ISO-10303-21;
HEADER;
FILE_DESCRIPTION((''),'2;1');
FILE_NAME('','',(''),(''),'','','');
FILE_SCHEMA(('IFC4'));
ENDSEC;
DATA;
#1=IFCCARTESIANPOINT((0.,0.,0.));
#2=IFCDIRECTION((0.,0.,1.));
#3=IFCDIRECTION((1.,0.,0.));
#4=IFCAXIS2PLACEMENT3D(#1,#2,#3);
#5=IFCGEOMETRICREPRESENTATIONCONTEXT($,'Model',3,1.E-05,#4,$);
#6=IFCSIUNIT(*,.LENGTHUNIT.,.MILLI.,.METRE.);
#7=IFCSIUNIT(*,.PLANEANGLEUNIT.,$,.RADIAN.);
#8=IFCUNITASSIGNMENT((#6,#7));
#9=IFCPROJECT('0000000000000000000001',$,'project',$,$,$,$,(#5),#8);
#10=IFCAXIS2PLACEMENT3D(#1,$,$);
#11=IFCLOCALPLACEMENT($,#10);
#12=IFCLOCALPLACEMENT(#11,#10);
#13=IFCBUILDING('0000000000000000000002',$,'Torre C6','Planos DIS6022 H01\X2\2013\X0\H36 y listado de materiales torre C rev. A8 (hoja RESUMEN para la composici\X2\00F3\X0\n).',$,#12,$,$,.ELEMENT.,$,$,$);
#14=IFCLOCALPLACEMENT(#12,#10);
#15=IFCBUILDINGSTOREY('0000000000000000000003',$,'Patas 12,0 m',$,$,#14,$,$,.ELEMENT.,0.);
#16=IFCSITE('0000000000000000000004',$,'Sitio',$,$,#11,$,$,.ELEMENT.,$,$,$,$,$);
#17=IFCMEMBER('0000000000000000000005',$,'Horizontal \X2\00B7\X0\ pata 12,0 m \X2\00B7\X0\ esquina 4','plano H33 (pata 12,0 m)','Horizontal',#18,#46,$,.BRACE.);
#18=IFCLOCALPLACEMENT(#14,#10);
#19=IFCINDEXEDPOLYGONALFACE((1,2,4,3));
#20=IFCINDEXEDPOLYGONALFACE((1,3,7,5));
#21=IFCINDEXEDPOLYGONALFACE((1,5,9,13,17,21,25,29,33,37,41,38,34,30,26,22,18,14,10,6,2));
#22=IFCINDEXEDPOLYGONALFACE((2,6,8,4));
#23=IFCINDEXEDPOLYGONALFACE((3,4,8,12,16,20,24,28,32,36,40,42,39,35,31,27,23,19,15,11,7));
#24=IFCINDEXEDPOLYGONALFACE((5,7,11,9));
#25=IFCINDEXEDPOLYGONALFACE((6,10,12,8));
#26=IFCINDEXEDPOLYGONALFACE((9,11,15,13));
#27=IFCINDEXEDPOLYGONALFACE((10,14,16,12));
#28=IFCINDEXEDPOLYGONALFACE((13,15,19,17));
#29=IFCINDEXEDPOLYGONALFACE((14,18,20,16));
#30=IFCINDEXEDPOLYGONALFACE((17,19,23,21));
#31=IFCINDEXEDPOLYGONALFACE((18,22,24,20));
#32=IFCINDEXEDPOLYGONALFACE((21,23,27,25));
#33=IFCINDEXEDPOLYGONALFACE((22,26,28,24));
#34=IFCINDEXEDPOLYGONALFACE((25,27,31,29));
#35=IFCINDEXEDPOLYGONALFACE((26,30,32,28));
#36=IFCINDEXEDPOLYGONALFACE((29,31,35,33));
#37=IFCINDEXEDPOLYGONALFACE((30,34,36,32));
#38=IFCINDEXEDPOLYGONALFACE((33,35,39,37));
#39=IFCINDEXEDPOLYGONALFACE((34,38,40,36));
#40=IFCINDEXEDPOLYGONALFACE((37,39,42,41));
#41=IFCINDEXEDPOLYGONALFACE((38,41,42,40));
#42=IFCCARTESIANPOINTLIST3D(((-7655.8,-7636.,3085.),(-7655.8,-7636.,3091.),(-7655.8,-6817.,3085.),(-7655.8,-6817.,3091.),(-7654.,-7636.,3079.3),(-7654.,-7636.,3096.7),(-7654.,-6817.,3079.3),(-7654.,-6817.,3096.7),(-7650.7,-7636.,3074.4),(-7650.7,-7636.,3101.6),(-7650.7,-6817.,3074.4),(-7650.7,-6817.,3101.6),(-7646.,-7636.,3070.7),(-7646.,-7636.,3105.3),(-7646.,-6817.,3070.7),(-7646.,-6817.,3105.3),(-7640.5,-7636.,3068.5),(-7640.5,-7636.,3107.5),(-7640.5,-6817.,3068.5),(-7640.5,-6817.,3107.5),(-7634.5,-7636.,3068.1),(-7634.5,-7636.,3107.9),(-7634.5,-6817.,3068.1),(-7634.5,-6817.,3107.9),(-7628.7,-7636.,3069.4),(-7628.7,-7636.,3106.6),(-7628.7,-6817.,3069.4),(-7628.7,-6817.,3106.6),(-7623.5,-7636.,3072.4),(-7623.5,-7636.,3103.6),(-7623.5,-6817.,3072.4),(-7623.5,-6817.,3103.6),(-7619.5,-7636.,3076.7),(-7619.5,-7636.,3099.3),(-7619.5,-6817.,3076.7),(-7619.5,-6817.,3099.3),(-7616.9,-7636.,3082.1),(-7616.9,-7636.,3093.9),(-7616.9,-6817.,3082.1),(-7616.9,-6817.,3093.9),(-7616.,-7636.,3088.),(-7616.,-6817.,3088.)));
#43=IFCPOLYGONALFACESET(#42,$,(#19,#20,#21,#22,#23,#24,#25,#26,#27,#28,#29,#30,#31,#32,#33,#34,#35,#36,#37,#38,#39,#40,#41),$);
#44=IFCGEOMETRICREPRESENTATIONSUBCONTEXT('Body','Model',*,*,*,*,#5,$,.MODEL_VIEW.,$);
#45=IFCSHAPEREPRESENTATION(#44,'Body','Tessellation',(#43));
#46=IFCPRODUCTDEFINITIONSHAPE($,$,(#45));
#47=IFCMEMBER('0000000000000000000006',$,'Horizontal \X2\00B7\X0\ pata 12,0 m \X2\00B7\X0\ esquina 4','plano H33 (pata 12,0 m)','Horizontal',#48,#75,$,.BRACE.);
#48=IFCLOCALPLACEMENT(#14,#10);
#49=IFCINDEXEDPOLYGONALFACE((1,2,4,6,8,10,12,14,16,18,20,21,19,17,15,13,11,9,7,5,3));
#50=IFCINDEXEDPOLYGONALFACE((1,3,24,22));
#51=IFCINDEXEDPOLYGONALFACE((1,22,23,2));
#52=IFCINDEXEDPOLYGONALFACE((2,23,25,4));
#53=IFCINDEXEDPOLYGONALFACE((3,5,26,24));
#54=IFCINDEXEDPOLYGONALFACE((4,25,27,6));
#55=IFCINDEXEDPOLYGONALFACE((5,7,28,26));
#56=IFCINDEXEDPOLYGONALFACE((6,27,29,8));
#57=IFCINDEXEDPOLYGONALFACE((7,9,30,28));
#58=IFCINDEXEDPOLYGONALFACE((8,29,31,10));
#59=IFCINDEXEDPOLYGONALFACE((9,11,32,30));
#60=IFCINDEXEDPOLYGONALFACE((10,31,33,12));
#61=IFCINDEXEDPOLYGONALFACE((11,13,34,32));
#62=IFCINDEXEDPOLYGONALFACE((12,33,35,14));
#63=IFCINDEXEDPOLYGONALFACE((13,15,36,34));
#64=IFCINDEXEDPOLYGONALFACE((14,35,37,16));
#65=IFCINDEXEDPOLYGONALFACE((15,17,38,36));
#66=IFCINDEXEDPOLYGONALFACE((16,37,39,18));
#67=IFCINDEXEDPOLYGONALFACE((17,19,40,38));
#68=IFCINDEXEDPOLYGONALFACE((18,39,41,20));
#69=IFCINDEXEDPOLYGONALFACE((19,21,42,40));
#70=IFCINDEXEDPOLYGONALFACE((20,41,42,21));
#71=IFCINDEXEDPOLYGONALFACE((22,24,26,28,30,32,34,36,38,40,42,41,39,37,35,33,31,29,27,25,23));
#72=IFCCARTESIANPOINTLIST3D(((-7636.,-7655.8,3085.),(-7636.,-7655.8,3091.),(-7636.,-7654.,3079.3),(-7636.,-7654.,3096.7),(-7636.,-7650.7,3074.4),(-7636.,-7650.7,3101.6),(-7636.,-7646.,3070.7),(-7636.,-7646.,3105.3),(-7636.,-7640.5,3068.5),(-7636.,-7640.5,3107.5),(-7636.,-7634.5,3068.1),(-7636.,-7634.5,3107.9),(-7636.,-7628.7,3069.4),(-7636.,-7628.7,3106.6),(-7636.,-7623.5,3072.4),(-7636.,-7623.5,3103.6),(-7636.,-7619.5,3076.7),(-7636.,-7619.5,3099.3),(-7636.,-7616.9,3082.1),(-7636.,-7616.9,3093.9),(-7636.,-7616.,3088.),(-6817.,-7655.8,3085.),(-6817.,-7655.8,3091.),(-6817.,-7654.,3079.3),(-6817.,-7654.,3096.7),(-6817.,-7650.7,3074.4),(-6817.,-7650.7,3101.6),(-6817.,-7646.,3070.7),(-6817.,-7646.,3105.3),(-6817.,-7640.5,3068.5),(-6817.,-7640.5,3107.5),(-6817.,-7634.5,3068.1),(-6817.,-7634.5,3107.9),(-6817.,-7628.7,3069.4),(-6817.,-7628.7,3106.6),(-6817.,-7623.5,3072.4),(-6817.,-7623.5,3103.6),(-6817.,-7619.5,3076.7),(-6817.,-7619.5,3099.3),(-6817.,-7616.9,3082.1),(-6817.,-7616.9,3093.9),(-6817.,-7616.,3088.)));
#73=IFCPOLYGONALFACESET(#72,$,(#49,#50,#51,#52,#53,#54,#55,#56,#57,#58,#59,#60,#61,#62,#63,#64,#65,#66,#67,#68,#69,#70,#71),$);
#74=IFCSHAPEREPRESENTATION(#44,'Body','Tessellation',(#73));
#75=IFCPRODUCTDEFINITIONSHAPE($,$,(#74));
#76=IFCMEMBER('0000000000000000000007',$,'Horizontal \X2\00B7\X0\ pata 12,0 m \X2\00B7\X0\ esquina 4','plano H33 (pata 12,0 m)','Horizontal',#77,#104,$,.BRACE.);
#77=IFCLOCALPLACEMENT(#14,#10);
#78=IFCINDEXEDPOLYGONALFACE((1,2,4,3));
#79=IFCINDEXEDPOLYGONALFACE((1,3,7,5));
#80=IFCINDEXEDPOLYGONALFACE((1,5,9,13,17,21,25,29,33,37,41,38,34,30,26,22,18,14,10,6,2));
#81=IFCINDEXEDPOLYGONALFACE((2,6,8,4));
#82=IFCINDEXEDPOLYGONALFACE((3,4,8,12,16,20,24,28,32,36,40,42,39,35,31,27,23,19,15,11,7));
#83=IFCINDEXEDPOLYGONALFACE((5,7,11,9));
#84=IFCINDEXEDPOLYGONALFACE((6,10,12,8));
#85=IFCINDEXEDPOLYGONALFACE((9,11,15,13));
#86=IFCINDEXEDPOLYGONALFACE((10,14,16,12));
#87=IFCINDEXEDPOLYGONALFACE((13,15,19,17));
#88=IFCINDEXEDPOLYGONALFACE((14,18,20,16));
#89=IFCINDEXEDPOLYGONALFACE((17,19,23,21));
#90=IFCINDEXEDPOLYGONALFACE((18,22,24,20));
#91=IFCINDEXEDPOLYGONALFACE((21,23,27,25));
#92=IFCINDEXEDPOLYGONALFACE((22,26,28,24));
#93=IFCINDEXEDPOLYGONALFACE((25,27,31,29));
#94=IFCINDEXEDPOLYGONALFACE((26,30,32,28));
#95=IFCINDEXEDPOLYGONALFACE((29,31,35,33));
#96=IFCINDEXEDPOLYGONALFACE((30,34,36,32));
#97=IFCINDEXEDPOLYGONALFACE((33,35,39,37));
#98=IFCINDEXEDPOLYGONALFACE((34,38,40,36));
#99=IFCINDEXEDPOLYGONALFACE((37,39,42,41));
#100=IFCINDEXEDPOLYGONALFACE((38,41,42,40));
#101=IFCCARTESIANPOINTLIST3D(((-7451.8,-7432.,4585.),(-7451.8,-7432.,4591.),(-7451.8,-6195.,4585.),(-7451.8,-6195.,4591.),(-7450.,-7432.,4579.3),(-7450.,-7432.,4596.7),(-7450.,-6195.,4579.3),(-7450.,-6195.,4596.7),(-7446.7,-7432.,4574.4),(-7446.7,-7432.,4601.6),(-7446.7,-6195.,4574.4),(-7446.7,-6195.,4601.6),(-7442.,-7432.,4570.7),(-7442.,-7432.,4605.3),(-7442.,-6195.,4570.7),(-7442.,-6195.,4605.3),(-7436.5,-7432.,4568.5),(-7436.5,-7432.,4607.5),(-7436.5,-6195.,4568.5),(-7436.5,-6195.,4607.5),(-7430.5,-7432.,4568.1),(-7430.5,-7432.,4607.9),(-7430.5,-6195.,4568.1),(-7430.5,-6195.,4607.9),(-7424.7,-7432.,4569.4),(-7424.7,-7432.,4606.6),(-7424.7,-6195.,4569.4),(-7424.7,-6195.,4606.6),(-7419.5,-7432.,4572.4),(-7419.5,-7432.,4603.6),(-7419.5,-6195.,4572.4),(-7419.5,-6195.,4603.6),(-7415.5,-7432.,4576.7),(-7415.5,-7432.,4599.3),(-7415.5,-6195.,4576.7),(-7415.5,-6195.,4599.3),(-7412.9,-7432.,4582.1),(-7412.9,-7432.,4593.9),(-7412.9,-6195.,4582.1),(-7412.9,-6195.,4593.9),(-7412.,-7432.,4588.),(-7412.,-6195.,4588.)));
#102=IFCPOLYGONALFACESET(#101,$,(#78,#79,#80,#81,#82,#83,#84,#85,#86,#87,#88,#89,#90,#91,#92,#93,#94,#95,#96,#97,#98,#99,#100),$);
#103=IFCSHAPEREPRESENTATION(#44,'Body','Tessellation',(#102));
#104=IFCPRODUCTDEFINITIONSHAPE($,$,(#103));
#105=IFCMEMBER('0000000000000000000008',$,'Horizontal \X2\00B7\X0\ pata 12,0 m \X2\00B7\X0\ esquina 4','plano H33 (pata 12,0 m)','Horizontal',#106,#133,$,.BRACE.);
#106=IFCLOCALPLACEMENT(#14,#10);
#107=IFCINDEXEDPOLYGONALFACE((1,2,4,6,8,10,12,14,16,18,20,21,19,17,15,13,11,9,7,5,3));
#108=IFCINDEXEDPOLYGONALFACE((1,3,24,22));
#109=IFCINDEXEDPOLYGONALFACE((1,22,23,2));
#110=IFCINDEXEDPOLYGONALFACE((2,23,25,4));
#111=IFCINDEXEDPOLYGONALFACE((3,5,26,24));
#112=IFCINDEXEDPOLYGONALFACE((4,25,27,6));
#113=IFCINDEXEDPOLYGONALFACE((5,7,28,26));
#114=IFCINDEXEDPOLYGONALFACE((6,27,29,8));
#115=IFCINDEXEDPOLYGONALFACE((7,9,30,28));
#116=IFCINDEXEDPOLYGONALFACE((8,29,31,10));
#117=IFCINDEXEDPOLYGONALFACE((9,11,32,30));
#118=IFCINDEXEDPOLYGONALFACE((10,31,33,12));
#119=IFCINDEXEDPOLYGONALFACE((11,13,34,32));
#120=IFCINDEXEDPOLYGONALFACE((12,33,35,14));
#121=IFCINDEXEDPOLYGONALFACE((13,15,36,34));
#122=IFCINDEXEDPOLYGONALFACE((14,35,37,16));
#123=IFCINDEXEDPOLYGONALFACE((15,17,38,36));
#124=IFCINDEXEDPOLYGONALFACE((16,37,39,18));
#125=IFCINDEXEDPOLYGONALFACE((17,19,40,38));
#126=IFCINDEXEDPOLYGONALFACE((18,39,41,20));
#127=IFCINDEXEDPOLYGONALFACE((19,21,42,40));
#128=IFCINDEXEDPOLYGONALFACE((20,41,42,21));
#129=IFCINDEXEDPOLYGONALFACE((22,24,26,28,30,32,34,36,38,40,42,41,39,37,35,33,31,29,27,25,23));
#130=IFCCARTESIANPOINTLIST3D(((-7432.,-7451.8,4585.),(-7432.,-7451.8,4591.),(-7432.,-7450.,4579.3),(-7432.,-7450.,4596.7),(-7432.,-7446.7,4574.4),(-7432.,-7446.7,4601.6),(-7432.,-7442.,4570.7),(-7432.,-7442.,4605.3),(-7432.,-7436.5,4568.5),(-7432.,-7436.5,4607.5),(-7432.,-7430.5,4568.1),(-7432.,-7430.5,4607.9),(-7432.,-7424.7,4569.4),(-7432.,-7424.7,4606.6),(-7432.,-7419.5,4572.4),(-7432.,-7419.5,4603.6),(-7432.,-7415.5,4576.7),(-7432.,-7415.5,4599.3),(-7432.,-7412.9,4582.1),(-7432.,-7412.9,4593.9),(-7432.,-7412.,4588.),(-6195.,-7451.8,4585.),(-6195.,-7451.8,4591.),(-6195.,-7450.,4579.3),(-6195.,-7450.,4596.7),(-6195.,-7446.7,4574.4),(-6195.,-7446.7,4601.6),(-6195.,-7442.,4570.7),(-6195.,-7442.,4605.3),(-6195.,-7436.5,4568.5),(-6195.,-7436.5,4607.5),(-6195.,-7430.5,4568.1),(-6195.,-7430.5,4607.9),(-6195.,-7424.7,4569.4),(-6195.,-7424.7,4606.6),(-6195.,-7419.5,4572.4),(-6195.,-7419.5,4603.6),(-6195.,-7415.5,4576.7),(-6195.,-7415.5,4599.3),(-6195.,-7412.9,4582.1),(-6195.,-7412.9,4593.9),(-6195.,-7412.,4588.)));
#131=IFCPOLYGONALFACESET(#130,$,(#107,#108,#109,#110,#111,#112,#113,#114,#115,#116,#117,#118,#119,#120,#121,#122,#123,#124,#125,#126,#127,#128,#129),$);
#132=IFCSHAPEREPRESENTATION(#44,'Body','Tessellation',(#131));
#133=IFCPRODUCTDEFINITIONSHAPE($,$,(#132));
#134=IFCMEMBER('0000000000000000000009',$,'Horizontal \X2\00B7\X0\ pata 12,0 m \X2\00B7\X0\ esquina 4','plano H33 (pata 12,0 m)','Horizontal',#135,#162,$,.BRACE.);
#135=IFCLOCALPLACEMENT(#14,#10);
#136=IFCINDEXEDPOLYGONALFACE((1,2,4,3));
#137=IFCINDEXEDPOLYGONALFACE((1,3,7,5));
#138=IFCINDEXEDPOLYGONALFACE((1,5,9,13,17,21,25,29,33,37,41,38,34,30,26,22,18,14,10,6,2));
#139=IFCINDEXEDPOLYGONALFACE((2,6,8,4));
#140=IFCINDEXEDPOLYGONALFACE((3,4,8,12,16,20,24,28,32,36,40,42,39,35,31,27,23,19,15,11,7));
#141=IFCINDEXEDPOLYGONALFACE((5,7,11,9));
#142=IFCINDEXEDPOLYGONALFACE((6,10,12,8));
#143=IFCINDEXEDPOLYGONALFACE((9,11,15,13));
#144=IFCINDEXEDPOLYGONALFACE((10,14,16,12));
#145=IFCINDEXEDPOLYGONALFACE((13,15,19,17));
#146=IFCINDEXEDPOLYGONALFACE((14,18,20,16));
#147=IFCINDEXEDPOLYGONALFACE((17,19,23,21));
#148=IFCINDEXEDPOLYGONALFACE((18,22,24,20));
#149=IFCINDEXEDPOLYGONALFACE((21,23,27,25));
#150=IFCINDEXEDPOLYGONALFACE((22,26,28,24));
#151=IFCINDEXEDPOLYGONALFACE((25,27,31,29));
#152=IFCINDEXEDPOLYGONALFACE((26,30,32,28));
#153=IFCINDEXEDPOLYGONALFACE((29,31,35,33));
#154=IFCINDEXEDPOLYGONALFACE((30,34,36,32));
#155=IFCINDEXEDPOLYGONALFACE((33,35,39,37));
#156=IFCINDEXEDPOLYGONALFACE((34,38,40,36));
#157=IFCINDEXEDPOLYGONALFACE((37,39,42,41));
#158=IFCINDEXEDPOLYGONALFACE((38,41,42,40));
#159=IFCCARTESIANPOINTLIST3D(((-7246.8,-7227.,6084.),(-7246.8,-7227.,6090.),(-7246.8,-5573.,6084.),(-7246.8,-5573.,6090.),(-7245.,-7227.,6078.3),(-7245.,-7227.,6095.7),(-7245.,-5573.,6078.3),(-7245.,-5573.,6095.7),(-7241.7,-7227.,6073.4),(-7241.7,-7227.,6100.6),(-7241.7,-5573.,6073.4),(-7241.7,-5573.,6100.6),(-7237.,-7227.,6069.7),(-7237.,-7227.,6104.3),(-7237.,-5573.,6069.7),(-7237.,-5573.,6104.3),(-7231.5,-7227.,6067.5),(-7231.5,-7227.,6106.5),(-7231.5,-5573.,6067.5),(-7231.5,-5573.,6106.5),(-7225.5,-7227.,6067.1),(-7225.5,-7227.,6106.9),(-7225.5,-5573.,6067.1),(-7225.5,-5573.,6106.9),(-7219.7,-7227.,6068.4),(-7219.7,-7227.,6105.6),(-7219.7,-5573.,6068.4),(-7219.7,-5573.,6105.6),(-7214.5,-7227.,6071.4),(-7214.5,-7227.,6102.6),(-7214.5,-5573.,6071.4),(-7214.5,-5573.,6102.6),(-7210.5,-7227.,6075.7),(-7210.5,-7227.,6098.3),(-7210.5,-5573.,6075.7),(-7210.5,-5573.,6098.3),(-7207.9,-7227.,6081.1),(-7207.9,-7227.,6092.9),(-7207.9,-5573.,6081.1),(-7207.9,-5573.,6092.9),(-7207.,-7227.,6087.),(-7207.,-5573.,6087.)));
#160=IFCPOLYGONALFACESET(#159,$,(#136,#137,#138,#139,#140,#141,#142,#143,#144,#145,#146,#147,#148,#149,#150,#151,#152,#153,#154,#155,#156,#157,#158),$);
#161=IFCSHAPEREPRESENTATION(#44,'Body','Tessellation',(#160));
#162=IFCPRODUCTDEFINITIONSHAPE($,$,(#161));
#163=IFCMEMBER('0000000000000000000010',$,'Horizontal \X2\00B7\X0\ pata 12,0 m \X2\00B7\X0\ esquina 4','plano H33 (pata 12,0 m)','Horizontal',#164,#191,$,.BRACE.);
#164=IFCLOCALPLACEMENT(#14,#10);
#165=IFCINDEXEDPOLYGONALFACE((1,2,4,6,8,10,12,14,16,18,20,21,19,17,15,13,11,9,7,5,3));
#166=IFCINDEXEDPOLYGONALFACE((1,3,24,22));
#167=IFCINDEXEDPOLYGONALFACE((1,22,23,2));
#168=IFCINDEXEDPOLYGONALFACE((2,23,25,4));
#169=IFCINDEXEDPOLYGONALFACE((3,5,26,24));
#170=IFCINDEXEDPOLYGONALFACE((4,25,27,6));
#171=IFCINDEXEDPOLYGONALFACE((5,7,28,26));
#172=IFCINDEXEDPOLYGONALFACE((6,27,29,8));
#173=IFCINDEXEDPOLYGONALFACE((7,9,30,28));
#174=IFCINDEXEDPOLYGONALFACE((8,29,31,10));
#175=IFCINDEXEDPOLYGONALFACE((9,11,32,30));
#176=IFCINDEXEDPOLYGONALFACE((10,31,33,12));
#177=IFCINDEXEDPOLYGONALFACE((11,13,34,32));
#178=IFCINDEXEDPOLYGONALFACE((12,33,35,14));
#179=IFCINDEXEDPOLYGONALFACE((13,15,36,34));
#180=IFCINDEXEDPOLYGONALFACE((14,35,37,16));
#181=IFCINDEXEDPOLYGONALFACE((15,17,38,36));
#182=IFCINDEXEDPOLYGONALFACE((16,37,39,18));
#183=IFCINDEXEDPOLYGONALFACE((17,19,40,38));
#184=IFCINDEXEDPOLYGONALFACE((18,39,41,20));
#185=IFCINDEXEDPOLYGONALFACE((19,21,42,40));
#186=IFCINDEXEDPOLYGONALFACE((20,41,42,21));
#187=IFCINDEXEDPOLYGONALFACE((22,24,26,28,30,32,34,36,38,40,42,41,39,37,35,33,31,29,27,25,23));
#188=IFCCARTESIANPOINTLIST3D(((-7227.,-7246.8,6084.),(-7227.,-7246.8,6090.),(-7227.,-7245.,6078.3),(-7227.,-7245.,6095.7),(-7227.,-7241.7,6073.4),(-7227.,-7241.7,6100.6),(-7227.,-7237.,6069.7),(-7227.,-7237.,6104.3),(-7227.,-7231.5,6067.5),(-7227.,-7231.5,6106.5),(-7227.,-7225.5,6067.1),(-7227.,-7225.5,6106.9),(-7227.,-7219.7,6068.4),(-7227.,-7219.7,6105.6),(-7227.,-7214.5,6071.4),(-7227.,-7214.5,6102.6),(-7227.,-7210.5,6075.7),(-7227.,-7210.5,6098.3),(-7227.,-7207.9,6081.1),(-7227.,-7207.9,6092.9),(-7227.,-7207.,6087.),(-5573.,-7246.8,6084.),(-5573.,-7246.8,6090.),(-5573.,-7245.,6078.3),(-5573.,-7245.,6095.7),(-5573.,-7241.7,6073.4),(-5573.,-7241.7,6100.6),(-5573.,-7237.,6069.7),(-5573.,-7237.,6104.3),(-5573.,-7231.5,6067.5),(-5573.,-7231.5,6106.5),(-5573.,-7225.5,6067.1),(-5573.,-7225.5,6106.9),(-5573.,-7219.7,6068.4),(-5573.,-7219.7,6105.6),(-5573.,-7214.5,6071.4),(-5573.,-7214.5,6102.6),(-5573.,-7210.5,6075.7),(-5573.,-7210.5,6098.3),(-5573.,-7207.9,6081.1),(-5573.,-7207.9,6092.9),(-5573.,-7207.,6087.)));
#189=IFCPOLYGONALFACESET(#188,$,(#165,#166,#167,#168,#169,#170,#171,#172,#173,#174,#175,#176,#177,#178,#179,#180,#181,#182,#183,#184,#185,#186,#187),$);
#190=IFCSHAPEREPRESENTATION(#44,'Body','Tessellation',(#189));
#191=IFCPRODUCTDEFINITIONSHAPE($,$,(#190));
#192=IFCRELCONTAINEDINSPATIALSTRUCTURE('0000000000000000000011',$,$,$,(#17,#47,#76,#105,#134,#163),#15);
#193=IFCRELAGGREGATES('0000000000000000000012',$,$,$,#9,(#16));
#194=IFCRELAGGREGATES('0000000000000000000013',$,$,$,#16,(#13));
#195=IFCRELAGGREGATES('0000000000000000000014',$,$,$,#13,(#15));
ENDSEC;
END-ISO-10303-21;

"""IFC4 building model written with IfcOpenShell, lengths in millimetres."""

from ifc_helpers import new_model, si_unit, frame, origin, origin_with_axes, place, context, subcontext, project, spatial, circle, extrude, element, save


model = new_model("IFC4")

# Units and contexts
model_context = context("Model", 3, precision=1e-05, world=origin_with_axes())
body_context = subcontext(model_context, "Body", "Model", "MODEL_VIEW")
ifc_project = project(units=[si_unit("LENGTHUNIT", "METRE", prefix="MILLI"), si_unit("PLANEANGLEUNIT", "RADIAN")], contexts=[model_context])

# Site, building, storey
site_placement = place(None, origin())
site = spatial("IfcSite", under=ifc_project, at=site_placement, Name="Sitio", CompositionType="ELEMENT")
building_placement = place(site_placement, origin())
building = spatial("IfcBuilding", under=site, at=building_placement, Name="Torre C6", Description="Planos DIS6022 H01–H36 y listado de materiales torre C rev. A8 (hoja RESUMEN para la composición).", CompositionType="ELEMENT")
storey_placement = place(building_placement, origin())
storey = spatial("IfcBuildingStorey", under=building, at=storey_placement, Name="Patas 12,0 m", CompositionType="ELEMENT", Elevation=0.0)

# Members
for number, where, z_axis, x_axis, name in (
    (1, (-7636.0, -7636.0, 3088.0), (0.0, 1.0, 0.0), (1.0, 0.0, 0.0), "Horizontal · pata 12,0 m · esquina 4"),
    (2, (-7636.0, -7636.0, 3088.0), (1.0, 0.0, 0.0), (0.0, 1.0, 0.0), "Horizontal · pata 12,0 m · esquina 4"),
):
    element("IfcMember", number, at=place(storey_placement, frame(where, z_axis=z_axis, x_axis=x_axis)), inside=storey, Name=name, Description="plano H33 (pata 12,0 m)", ObjectType="Horizontal", PredefinedType="BRACE", context=body_context, shape_type="SweptSolid", body=[
        extrude(circle(Radius=20.0), None, (0.0, 0.0, 1.0), 819.0),
    ])
for number, where, z_axis, x_axis, name in (
    (3, (-7432.0, -7432.0, 4588.0), (0.0, 1.0, 0.0), (1.0, 0.0, 0.0), "Horizontal · pata 12,0 m · esquina 4"),
    (4, (-7432.0, -7432.0, 4588.0), (1.0, 0.0, 0.0), (0.0, 1.0, 0.0), "Horizontal · pata 12,0 m · esquina 4"),
):
    element("IfcMember", number, at=place(storey_placement, frame(where, z_axis=z_axis, x_axis=x_axis)), inside=storey, Name=name, Description="plano H33 (pata 12,0 m)", ObjectType="Horizontal", PredefinedType="BRACE", context=body_context, shape_type="SweptSolid", body=[
        extrude(circle(Radius=20.0), None, (0.0, 0.0, 1.0), 1237.0),
    ])
for number, where, z_axis, x_axis, name in (
    (5, (-7227.0, -5573.0, 6087.0), (0.0, -1.0, 0.0), (1.0, 0.0, 0.0), "Horizontal · pata 12,0 m · esquina 4"),
    (6, (-5573.0, -7227.0, 6087.0), (-1.0, 0.0, 0.0), (0.0, 1.0, 0.0), "Horizontal · pata 12,0 m · esquina 4"),
):
    element("IfcMember", number, at=place(storey_placement, frame(where, z_axis=z_axis, x_axis=x_axis)), inside=storey, Name=name, Description="plano H33 (pata 12,0 m)", ObjectType="Horizontal", PredefinedType="BRACE", context=body_context, shape_type="SweptSolid", body=[
        extrude(circle(Radius=20.0), None, (0.0, 0.0, 1.0), 1654.0),
    ])

save(model, "model.ifc")
